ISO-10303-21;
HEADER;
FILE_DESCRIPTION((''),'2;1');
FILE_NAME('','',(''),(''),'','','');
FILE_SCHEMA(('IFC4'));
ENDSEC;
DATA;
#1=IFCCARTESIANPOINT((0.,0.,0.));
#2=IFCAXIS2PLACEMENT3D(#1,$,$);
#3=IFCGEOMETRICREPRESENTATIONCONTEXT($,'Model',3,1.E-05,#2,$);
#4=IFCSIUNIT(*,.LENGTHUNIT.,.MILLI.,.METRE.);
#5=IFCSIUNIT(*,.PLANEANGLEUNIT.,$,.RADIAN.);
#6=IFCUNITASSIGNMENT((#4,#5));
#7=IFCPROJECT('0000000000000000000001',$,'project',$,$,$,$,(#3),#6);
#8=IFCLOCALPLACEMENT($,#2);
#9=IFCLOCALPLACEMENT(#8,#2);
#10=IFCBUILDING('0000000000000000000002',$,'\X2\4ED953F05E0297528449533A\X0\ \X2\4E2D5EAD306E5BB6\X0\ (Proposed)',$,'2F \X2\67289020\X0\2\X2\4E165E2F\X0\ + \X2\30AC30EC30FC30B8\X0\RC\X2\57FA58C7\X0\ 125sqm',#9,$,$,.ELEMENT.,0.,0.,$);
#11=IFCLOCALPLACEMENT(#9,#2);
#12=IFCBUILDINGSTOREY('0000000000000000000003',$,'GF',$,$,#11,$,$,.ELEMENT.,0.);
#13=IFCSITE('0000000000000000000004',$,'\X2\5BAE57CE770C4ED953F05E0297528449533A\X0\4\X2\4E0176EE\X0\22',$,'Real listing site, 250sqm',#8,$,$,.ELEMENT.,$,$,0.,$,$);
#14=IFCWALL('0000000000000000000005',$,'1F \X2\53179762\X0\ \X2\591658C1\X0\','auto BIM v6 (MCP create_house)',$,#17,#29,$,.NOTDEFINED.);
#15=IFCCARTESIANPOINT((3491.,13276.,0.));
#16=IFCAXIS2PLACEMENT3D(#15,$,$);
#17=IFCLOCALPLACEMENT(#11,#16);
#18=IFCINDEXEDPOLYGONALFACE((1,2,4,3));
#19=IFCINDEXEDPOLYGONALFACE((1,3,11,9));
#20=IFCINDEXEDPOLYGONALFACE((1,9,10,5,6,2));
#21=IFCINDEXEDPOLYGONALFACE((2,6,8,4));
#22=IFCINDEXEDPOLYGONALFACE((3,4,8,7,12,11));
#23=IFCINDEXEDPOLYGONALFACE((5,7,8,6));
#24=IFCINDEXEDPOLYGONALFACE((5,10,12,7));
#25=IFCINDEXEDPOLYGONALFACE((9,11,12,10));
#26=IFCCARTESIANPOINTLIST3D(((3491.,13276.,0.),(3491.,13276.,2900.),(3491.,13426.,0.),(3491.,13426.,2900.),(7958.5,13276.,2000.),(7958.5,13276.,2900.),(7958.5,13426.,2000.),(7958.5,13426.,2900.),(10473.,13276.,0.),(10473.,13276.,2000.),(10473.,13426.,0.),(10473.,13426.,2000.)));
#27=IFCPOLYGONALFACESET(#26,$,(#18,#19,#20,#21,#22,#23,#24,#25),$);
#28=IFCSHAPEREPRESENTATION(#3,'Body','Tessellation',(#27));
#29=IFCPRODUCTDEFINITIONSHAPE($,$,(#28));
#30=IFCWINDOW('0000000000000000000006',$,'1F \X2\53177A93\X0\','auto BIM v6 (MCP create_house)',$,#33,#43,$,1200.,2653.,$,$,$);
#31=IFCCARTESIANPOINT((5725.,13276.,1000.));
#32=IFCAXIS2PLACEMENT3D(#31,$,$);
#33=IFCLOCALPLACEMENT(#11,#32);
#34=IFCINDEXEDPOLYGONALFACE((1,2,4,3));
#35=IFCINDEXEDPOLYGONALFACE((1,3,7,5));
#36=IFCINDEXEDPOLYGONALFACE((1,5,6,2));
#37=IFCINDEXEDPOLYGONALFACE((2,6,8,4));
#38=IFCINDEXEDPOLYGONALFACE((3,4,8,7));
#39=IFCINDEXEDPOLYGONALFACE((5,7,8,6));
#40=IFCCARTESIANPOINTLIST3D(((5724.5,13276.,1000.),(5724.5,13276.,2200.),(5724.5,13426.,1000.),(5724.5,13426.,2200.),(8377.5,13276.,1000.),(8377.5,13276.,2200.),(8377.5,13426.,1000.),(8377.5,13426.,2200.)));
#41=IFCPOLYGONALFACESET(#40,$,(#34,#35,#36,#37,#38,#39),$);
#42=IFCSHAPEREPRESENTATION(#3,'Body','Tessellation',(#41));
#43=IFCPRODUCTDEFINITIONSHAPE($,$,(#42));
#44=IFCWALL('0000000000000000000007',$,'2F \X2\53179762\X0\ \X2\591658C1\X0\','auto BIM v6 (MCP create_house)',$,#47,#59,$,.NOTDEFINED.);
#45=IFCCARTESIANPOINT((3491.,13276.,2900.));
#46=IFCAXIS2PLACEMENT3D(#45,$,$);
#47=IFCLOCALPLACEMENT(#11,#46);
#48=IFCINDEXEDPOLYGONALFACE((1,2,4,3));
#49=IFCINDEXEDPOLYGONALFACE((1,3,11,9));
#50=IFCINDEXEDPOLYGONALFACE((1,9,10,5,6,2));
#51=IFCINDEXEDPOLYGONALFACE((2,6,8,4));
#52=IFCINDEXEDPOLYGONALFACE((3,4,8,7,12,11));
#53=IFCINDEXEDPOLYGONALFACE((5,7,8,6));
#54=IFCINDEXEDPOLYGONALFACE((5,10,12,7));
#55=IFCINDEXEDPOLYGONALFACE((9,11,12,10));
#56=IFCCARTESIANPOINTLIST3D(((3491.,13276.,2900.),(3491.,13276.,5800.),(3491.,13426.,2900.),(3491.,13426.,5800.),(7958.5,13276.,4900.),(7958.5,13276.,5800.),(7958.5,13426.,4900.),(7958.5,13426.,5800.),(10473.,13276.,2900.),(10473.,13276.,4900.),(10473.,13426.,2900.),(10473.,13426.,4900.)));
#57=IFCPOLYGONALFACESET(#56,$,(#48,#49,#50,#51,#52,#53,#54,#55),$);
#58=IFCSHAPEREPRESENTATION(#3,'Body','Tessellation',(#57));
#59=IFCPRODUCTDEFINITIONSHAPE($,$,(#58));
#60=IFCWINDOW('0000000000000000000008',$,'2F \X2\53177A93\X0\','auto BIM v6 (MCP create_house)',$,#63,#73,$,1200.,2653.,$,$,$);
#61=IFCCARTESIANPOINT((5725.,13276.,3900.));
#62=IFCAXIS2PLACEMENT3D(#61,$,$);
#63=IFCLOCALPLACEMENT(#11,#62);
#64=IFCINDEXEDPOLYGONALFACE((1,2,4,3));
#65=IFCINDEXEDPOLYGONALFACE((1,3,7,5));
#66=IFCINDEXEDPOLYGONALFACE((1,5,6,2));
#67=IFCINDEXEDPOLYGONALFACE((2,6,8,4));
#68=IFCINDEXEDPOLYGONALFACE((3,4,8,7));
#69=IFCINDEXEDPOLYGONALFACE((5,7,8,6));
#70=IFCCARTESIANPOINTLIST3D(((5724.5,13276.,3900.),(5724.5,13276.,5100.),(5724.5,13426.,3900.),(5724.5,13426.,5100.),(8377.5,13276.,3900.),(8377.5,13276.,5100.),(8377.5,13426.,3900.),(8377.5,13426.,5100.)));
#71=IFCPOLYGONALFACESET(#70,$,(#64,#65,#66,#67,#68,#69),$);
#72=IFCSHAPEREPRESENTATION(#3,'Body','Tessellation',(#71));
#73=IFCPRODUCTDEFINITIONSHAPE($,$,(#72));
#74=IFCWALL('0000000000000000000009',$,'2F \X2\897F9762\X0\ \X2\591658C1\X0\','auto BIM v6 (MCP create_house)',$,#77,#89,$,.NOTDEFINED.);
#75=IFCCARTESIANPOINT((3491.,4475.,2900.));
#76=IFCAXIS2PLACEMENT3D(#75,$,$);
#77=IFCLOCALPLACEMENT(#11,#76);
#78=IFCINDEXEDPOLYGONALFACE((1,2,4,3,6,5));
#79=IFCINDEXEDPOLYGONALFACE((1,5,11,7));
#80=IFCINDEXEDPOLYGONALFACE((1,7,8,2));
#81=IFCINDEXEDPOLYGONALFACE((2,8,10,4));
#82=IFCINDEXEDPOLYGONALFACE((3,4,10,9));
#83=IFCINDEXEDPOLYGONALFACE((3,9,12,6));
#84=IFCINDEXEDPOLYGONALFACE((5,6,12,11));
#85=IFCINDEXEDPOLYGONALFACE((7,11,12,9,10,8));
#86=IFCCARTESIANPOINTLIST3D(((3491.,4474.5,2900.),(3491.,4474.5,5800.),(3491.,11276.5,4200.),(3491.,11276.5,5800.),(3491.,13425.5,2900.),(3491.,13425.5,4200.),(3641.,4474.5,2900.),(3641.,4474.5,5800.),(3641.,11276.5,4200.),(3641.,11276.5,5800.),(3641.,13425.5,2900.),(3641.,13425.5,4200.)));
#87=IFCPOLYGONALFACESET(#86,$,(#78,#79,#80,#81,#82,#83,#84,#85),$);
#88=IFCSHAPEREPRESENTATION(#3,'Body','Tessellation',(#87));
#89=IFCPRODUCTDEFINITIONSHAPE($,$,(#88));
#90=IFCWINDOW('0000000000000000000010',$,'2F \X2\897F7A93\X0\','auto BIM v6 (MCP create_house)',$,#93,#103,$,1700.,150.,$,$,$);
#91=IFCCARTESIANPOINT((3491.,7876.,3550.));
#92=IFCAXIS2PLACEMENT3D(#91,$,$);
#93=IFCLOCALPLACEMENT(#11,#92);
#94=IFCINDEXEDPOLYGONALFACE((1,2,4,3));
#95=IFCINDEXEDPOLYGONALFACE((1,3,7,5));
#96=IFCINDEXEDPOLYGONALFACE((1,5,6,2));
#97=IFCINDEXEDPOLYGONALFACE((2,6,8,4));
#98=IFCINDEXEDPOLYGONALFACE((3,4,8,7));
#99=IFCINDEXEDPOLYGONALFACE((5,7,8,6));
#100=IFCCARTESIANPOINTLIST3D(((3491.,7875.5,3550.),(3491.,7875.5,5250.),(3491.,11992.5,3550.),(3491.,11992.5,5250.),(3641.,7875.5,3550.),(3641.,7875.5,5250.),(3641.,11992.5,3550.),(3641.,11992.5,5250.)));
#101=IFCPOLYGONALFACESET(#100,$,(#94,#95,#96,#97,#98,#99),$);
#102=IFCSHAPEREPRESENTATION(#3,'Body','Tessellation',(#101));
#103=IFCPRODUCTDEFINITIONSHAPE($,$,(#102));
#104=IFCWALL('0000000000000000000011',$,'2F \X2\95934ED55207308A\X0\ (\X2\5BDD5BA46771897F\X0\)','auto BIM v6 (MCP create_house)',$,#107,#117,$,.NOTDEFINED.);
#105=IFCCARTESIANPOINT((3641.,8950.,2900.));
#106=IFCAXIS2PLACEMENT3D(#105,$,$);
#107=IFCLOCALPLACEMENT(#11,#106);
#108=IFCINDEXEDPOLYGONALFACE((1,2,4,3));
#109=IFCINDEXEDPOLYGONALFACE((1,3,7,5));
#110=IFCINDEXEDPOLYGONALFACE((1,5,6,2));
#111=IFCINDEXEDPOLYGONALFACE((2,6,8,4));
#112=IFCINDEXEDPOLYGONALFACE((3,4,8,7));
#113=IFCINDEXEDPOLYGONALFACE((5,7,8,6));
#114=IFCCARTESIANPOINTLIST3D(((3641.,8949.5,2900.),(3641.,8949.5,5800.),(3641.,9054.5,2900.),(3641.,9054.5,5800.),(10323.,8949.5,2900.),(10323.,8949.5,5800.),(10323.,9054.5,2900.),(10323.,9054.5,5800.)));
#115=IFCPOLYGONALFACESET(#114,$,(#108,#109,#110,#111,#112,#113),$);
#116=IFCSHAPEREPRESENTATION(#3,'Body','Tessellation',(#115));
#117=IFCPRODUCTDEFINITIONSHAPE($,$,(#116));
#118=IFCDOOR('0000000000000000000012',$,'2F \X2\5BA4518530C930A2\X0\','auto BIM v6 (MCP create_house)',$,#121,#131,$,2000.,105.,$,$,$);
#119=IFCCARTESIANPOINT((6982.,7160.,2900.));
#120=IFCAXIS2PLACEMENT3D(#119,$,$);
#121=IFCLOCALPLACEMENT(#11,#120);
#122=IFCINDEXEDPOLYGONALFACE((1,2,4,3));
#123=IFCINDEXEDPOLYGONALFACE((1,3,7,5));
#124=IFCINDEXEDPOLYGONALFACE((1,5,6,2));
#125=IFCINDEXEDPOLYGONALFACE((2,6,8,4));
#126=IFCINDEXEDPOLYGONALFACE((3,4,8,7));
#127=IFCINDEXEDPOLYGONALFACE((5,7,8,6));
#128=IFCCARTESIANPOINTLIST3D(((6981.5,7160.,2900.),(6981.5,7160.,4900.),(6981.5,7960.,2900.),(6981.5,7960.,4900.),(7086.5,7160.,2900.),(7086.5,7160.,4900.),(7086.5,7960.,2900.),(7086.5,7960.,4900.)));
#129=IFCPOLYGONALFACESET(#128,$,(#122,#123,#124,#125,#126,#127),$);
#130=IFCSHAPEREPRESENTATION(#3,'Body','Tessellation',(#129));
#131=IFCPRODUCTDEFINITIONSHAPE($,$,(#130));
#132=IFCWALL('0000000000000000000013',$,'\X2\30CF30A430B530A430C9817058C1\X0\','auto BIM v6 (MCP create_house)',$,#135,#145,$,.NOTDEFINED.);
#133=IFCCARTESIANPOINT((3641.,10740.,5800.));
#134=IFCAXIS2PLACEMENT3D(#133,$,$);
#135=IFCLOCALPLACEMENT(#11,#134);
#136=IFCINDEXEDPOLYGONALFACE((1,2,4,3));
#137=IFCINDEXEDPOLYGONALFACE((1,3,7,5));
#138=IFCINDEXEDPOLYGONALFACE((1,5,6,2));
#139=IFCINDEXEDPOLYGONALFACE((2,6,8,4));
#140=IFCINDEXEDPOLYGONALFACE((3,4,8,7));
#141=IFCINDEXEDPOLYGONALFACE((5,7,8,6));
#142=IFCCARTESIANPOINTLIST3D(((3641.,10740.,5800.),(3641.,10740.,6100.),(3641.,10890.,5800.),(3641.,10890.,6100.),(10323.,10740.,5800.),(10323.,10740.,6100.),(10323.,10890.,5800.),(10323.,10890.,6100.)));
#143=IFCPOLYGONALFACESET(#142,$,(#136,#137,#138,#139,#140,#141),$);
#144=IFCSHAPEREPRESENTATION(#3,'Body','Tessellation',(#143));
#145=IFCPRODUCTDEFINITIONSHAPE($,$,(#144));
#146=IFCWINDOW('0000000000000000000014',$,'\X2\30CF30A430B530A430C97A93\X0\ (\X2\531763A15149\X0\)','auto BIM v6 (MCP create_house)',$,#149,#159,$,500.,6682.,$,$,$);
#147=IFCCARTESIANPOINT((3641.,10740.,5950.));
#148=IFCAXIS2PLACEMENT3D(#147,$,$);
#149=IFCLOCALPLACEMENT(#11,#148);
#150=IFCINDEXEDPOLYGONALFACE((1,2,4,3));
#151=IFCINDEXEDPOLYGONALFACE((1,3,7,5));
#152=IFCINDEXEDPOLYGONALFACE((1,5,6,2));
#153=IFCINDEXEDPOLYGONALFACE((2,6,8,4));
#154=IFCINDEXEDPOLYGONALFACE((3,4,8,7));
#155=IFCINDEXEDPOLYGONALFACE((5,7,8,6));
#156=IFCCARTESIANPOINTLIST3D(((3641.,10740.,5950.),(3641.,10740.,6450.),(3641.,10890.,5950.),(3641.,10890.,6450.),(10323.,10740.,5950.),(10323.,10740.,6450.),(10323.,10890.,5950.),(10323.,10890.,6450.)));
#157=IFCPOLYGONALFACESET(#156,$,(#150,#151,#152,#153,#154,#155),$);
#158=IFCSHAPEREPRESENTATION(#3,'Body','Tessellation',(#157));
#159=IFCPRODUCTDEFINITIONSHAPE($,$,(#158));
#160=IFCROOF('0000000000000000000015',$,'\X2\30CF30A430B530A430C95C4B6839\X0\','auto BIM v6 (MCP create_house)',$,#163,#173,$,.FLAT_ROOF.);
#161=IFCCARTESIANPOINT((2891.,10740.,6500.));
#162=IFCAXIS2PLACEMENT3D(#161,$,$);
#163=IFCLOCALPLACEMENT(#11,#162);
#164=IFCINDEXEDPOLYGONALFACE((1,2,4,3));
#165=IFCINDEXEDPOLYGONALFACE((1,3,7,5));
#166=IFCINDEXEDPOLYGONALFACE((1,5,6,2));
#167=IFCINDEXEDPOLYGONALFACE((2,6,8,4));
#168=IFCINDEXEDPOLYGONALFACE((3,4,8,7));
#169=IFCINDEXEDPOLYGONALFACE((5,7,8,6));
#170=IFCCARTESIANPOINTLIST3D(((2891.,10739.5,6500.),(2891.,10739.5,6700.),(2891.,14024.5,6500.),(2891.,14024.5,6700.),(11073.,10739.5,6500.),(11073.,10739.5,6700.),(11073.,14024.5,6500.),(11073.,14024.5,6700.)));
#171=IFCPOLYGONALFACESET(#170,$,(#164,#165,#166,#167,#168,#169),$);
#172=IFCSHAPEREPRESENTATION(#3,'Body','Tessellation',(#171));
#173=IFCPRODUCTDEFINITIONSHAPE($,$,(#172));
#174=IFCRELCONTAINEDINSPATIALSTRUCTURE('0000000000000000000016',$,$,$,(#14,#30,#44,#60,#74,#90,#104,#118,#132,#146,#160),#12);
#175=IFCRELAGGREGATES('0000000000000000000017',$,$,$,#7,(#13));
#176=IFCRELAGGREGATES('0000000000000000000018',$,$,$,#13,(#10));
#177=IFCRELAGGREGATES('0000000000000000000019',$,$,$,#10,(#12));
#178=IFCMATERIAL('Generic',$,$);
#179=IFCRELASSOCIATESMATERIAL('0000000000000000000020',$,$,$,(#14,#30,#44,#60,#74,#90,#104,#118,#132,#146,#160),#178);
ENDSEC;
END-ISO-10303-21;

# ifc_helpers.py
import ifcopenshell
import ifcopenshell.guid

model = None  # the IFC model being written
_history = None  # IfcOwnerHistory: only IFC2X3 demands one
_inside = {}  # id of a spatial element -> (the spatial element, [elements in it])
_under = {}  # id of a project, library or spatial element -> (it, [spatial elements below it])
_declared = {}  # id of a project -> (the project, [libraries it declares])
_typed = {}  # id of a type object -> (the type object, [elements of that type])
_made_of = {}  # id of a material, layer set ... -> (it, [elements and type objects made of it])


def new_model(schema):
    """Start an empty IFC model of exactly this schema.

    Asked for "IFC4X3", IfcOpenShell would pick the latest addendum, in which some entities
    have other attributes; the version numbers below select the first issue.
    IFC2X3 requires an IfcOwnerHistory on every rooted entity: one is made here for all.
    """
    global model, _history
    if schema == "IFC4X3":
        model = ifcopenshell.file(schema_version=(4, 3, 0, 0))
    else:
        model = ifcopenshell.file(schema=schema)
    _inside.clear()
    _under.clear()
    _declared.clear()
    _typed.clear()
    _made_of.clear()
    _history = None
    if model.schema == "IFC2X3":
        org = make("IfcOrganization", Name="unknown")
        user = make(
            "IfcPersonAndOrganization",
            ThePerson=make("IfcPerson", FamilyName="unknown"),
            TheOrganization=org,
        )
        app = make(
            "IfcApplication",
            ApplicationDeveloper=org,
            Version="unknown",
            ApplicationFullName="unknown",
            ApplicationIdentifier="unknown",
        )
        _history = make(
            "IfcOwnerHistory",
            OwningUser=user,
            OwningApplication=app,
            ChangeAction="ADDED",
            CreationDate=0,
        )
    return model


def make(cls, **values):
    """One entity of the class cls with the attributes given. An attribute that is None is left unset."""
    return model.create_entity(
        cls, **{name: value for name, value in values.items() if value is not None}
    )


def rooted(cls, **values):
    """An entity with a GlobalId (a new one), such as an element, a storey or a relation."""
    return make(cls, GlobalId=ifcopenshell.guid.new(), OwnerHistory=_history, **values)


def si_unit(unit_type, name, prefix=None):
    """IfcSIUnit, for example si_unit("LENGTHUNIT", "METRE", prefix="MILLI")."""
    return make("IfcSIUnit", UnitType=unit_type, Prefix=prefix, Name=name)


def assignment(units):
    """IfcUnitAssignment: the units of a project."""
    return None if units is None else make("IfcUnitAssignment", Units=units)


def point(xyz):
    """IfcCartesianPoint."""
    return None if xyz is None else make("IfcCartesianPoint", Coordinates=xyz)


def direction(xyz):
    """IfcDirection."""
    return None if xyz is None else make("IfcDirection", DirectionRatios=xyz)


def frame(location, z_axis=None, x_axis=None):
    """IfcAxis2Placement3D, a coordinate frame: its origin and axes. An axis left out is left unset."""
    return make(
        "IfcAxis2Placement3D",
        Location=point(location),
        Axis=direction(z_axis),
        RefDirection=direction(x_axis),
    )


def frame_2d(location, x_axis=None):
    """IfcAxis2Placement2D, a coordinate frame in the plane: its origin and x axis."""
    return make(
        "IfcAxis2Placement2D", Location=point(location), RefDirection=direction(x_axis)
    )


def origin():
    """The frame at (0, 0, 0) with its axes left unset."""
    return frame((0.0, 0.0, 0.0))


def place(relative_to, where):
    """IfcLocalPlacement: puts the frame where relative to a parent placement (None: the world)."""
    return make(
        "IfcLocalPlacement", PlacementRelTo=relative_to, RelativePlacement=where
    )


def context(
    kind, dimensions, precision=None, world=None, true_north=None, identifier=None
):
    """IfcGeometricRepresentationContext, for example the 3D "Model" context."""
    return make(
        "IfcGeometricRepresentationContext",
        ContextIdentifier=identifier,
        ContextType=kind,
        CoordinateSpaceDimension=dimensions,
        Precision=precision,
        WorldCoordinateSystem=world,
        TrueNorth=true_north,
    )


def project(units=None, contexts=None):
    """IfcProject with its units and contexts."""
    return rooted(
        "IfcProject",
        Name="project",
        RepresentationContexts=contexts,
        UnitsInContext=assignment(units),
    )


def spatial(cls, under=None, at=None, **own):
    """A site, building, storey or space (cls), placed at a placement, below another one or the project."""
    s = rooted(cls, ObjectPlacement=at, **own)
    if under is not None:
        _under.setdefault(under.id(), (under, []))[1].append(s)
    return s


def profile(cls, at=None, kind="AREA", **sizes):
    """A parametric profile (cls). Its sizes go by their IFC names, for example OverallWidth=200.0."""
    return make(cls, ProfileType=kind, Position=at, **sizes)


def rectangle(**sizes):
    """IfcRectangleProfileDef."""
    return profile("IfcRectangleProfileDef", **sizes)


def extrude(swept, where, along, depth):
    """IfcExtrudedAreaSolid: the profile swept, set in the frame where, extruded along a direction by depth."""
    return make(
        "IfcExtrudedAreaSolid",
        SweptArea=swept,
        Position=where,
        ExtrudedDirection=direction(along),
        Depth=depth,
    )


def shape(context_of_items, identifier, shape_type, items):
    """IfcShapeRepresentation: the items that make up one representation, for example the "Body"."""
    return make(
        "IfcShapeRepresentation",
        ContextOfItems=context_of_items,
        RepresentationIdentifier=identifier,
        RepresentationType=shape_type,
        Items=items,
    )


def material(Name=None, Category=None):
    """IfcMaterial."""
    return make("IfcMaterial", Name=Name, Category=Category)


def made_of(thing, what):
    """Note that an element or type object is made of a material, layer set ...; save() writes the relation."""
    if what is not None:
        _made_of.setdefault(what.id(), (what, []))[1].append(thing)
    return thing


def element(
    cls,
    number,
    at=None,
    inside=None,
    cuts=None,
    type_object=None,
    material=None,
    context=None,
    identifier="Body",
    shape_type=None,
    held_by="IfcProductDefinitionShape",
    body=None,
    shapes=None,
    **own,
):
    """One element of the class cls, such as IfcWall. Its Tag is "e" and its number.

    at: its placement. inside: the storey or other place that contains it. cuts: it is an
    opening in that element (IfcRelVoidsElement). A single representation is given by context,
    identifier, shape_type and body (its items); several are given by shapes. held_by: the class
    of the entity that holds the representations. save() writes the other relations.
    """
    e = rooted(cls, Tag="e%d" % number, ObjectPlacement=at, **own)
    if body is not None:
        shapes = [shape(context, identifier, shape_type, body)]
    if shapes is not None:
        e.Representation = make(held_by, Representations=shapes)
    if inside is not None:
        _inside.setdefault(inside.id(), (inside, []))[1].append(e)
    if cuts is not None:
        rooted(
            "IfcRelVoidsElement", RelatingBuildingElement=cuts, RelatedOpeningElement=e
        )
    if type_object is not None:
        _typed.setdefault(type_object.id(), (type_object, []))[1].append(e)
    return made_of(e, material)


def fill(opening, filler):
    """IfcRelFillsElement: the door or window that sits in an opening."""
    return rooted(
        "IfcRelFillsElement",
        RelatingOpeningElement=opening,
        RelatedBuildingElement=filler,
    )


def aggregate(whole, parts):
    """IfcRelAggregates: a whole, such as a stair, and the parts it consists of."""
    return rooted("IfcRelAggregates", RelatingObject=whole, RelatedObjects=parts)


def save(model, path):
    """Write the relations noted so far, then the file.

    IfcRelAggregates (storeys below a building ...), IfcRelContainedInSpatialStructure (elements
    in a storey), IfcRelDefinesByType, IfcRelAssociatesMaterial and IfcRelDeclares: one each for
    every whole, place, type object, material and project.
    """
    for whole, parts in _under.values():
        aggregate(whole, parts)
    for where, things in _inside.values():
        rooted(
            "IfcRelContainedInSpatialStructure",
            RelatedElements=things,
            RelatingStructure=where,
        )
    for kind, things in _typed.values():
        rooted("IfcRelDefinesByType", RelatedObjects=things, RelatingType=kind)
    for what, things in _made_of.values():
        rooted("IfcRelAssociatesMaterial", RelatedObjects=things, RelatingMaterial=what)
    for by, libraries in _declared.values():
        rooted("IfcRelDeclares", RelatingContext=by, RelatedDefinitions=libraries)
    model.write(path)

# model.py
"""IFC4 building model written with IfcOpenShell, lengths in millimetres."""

from ifc_helpers import new_model, si_unit, frame, frame_2d, origin, place, context, project, spatial, rectangle, extrude, material, element, fill, save


model = new_model("IFC4")

# Units and contexts
model_context = context("Model", 3, precision=1e-05, world=origin())
ifc_project = project(units=[si_unit("LENGTHUNIT", "METRE", prefix="MILLI"), si_unit("PLANEANGLEUNIT", "RADIAN")], contexts=[model_context])

# Site, building, storey
site_placement = place(None, origin())
site = spatial("IfcSite", under=ifc_project, at=site_placement, Name="宮城県仙台市青葉区4丁目22", ObjectType="Real listing site, 250sqm", CompositionType="ELEMENT", RefElevation=0.0)
building_placement = place(site_placement, origin())
building = spatial("IfcBuilding", under=site, at=building_placement, Name="仙台市青葉区 中庭の家 (Proposed)", ObjectType="2F 木造2世帯 + ガレージRC基壇 125sqm", CompositionType="ELEMENT", ElevationOfRefHeight=0.0, ElevationOfTerrain=0.0)
storey_placement = place(building_placement, origin())
storey = spatial("IfcBuildingStorey", under=building, at=storey_placement, Name="GF", CompositionType="ELEMENT", Elevation=0.0)

# Wall, opening, window
ifc_material = material(Name="Generic")
wall_1_placement = place(storey_placement, frame((3491.0, 13276.0, 0.0)))
wall_1 = element("IfcWall", 1, at=wall_1_placement, inside=storey, material=ifc_material, Name="1F 北面 外壁", Description="auto BIM v6 (MCP create_house)", PredefinedType="NOTDEFINED", context=model_context, shape_type="SweptSolid", body=[
    extrude(rectangle(XDim=6982.0, YDim=150.0, at=frame_2d((3491.0, 75.0))), frame((3491.0, 13276.0, 0.0)), (0.0, 0.0, 1.0), 2900.0),
])
opening_1_placement = place(storey_placement, frame((5725.0, 13276.0, 1000.0)))
opening_1 = element("IfcOpeningElement", 2, at=opening_1_placement, cuts=wall_1, PredefinedType="NOTDEFINED", context=model_context, shape_type="SweptSolid", body=[
    extrude(rectangle(XDim=2653.0, YDim=150.0, at=frame_2d((1326.0, 75.0))), frame((5725.0, 13276.0, 1000.0)), (0.0, 0.0, 1.0), 1200.0),
])
window_1_placement = place(storey_placement, frame((5725.0, 13276.0, 1000.0)))
window_1 = element("IfcWindow", 3, at=window_1_placement, inside=storey, material=ifc_material, Name="1F 北窓", Description="auto BIM v6 (MCP create_house)", OverallHeight=1200.0, OverallWidth=2653.0, context=model_context, shape_type="SweptSolid", body=[
    extrude(rectangle(XDim=2653.0, YDim=150.0, at=frame_2d((1326.0, 75.0))), frame((5725.0, 13276.0, 1000.0)), (0.0, 0.0, 1.0), 1200.0),
])
fill(opening_1, window_1)

# Walls, openings, windows
wall_2_placement = place(storey_placement, frame((3491.0, 13276.0, 2900.0)))
wall_2 = element("IfcWall", 4, at=wall_2_placement, inside=storey, material=ifc_material, Name="2F 北面 外壁", Description="auto BIM v6 (MCP create_house)", PredefinedType="NOTDEFINED", context=model_context, shape_type="SweptSolid", body=[
    extrude(rectangle(XDim=6982.0, YDim=150.0, at=frame_2d((3491.0, 75.0))), frame((3491.0, 13276.0, 2900.0)), (0.0, 0.0, 1.0), 2900.0),
])
opening_2_placement = place(storey_placement, frame((5725.0, 13276.0, 3900.0)))
opening_2 = element("IfcOpeningElement", 5, at=opening_2_placement, cuts=wall_2, PredefinedType="NOTDEFINED", context=model_context, shape_type="SweptSolid", body=[
    extrude(rectangle(XDim=2653.0, YDim=150.0, at=frame_2d((1326.0, 75.0))), frame((5725.0, 13276.0, 3900.0)), (0.0, 0.0, 1.0), 1200.0),
])
window_2_placement = place(storey_placement, frame((5725.0, 13276.0, 3900.0)))
window_2 = element("IfcWindow", 6, at=window_2_placement, inside=storey, material=ifc_material, Name="2F 北窓", Description="auto BIM v6 (MCP create_house)", OverallHeight=1200.0, OverallWidth=2653.0, context=model_context, shape_type="SweptSolid", body=[
    extrude(rectangle(XDim=2653.0, YDim=150.0, at=frame_2d((1326.0, 75.0))), frame((5725.0, 13276.0, 3900.0)), (0.0, 0.0, 1.0), 1200.0),
])
fill(opening_2, window_2)
wall_3_placement = place(storey_placement, frame((3491.0, 4475.0, 2900.0)))
wall_3 = element("IfcWall", 7, at=wall_3_placement, inside=storey, material=ifc_material, Name="2F 西面 外壁", Description="auto BIM v6 (MCP create_house)", PredefinedType="NOTDEFINED", context=model_context, shape_type="SweptSolid", body=[
    extrude(rectangle(XDim=150.0, YDim=8951.0, at=frame_2d((75.0, 4475.0))), frame((3491.0, 4475.0, 2900.0)), (0.0, 0.0, 1.0), 2900.0),
])
opening_3_placement = place(storey_placement, frame((3491.0, 7876.0, 3550.0)))
opening_3 = element("IfcOpeningElement", 8, at=opening_3_placement, cuts=wall_3, PredefinedType="NOTDEFINED", context=model_context, shape_type="SweptSolid", body=[
    extrude(rectangle(XDim=150.0, YDim=4117.0, at=frame_2d((75.0, 2058.0))), frame((3491.0, 7876.0, 3550.0)), (0.0, 0.0, 1.0), 1700.0),
])
window_3_placement = place(storey_placement, frame((3491.0, 7876.0, 3550.0)))
window_3 = element("IfcWindow", 9, at=window_3_placement, inside=storey, material=ifc_material, Name="2F 西窓", Description="auto BIM v6 (MCP create_house)", OverallHeight=1700.0, OverallWidth=150.0, context=model_context, shape_type="SweptSolid", body=[
    extrude(rectangle(XDim=150.0, YDim=4117.0, at=frame_2d((75.0, 2058.0))), frame((3491.0, 7876.0, 3550.0)), (0.0, 0.0, 1.0), 1700.0),
])
fill(opening_3, window_3)

# Wall
wall_4_placement = place(storey_placement, frame((3641.0, 8950.0, 2900.0)))
element("IfcWall", 10, at=wall_4_placement, inside=storey, material=ifc_material, Name="2F 間仕切り (寝室東西)", Description="auto BIM v6 (MCP create_house)", PredefinedType="NOTDEFINED", context=model_context, shape_type="SweptSolid", body=[
    extrude(rectangle(XDim=6682.0, YDim=105.0, at=frame_2d((3341.0, 52.0))), frame((3641.0, 8950.0, 2900.0)), (0.0, 0.0, 1.0), 2900.0),
])

# Door
door_placement = place(storey_placement, frame((6982.0, 7160.0, 2900.0)))
element("IfcDoor", 11, at=door_placement, inside=storey, material=ifc_material, Name="2F 室内ドア", Description="auto BIM v6 (MCP create_house)", OverallHeight=2000.0, OverallWidth=105.0, context=model_context, shape_type="SweptSolid", body=[
    extrude(rectangle(XDim=105.0, YDim=800.0, at=frame_2d((52.0, 400.0))), frame((6982.0, 7160.0, 2900.0)), (0.0, 0.0, 1.0), 2000.0),
])

# Wall, opening, window
wall_5_placement = place(storey_placement, frame((3641.0, 10740.0, 5800.0)))
wall_5 = element("IfcWall", 12, at=wall_5_placement, inside=storey, material=ifc_material, Name="ハイサイド腰壁", Description="auto BIM v6 (MCP create_house)", PredefinedType="NOTDEFINED", context=model_context, shape_type="SweptSolid", body=[
    extrude(rectangle(XDim=6682.0, YDim=150.0, at=frame_2d((3341.0, 75.0))), frame((3641.0, 10740.0, 5800.0)), (0.0, 0.0, 1.0), 700.0),
])
opening_4_placement = place(storey_placement, frame((3641.0, 10740.0, 5950.0)))
opening_4 = element("IfcOpeningElement", 13, at=opening_4_placement, cuts=wall_5, PredefinedType="NOTDEFINED", context=model_context, shape_type="SweptSolid", body=[
    extrude(rectangle(XDim=6682.0, YDim=150.0, at=frame_2d((3341.0, 75.0))), frame((3641.0, 10740.0, 5950.0)), (0.0, 0.0, 1.0), 500.0),
])
window_4_placement = place(storey_placement, frame((3641.0, 10740.0, 5950.0)))
window_4 = element("IfcWindow", 14, at=window_4_placement, inside=storey, material=ifc_material, Name="ハイサイド窓 (北採光)", Description="auto BIM v6 (MCP create_house)", OverallHeight=500.0, OverallWidth=6682.0, context=model_context, shape_type="SweptSolid", body=[
    extrude(rectangle(XDim=6682.0, YDim=150.0, at=frame_2d((3341.0, 75.0))), frame((3641.0, 10740.0, 5950.0)), (0.0, 0.0, 1.0), 500.0),
])
fill(opening_4, window_4)

# Roof
roof_placement = place(storey_placement, frame((2891.0, 10740.0, 6500.0)))
element("IfcRoof", 15, at=roof_placement, inside=storey, material=ifc_material, Name="ハイサイド屋根", Description="auto BIM v6 (MCP create_house)", PredefinedType="FLAT_ROOF", context=model_context, shape_type="SweptSolid", body=[
    extrude(rectangle(XDim=8182.0, YDim=3285.0, at=frame_2d((4091.0, 1642.0))), frame((2891.0, 10740.0, 6500.0)), (0.0, 0.0, 1.0), 200.0),
])

save(model, "model.ifc")
